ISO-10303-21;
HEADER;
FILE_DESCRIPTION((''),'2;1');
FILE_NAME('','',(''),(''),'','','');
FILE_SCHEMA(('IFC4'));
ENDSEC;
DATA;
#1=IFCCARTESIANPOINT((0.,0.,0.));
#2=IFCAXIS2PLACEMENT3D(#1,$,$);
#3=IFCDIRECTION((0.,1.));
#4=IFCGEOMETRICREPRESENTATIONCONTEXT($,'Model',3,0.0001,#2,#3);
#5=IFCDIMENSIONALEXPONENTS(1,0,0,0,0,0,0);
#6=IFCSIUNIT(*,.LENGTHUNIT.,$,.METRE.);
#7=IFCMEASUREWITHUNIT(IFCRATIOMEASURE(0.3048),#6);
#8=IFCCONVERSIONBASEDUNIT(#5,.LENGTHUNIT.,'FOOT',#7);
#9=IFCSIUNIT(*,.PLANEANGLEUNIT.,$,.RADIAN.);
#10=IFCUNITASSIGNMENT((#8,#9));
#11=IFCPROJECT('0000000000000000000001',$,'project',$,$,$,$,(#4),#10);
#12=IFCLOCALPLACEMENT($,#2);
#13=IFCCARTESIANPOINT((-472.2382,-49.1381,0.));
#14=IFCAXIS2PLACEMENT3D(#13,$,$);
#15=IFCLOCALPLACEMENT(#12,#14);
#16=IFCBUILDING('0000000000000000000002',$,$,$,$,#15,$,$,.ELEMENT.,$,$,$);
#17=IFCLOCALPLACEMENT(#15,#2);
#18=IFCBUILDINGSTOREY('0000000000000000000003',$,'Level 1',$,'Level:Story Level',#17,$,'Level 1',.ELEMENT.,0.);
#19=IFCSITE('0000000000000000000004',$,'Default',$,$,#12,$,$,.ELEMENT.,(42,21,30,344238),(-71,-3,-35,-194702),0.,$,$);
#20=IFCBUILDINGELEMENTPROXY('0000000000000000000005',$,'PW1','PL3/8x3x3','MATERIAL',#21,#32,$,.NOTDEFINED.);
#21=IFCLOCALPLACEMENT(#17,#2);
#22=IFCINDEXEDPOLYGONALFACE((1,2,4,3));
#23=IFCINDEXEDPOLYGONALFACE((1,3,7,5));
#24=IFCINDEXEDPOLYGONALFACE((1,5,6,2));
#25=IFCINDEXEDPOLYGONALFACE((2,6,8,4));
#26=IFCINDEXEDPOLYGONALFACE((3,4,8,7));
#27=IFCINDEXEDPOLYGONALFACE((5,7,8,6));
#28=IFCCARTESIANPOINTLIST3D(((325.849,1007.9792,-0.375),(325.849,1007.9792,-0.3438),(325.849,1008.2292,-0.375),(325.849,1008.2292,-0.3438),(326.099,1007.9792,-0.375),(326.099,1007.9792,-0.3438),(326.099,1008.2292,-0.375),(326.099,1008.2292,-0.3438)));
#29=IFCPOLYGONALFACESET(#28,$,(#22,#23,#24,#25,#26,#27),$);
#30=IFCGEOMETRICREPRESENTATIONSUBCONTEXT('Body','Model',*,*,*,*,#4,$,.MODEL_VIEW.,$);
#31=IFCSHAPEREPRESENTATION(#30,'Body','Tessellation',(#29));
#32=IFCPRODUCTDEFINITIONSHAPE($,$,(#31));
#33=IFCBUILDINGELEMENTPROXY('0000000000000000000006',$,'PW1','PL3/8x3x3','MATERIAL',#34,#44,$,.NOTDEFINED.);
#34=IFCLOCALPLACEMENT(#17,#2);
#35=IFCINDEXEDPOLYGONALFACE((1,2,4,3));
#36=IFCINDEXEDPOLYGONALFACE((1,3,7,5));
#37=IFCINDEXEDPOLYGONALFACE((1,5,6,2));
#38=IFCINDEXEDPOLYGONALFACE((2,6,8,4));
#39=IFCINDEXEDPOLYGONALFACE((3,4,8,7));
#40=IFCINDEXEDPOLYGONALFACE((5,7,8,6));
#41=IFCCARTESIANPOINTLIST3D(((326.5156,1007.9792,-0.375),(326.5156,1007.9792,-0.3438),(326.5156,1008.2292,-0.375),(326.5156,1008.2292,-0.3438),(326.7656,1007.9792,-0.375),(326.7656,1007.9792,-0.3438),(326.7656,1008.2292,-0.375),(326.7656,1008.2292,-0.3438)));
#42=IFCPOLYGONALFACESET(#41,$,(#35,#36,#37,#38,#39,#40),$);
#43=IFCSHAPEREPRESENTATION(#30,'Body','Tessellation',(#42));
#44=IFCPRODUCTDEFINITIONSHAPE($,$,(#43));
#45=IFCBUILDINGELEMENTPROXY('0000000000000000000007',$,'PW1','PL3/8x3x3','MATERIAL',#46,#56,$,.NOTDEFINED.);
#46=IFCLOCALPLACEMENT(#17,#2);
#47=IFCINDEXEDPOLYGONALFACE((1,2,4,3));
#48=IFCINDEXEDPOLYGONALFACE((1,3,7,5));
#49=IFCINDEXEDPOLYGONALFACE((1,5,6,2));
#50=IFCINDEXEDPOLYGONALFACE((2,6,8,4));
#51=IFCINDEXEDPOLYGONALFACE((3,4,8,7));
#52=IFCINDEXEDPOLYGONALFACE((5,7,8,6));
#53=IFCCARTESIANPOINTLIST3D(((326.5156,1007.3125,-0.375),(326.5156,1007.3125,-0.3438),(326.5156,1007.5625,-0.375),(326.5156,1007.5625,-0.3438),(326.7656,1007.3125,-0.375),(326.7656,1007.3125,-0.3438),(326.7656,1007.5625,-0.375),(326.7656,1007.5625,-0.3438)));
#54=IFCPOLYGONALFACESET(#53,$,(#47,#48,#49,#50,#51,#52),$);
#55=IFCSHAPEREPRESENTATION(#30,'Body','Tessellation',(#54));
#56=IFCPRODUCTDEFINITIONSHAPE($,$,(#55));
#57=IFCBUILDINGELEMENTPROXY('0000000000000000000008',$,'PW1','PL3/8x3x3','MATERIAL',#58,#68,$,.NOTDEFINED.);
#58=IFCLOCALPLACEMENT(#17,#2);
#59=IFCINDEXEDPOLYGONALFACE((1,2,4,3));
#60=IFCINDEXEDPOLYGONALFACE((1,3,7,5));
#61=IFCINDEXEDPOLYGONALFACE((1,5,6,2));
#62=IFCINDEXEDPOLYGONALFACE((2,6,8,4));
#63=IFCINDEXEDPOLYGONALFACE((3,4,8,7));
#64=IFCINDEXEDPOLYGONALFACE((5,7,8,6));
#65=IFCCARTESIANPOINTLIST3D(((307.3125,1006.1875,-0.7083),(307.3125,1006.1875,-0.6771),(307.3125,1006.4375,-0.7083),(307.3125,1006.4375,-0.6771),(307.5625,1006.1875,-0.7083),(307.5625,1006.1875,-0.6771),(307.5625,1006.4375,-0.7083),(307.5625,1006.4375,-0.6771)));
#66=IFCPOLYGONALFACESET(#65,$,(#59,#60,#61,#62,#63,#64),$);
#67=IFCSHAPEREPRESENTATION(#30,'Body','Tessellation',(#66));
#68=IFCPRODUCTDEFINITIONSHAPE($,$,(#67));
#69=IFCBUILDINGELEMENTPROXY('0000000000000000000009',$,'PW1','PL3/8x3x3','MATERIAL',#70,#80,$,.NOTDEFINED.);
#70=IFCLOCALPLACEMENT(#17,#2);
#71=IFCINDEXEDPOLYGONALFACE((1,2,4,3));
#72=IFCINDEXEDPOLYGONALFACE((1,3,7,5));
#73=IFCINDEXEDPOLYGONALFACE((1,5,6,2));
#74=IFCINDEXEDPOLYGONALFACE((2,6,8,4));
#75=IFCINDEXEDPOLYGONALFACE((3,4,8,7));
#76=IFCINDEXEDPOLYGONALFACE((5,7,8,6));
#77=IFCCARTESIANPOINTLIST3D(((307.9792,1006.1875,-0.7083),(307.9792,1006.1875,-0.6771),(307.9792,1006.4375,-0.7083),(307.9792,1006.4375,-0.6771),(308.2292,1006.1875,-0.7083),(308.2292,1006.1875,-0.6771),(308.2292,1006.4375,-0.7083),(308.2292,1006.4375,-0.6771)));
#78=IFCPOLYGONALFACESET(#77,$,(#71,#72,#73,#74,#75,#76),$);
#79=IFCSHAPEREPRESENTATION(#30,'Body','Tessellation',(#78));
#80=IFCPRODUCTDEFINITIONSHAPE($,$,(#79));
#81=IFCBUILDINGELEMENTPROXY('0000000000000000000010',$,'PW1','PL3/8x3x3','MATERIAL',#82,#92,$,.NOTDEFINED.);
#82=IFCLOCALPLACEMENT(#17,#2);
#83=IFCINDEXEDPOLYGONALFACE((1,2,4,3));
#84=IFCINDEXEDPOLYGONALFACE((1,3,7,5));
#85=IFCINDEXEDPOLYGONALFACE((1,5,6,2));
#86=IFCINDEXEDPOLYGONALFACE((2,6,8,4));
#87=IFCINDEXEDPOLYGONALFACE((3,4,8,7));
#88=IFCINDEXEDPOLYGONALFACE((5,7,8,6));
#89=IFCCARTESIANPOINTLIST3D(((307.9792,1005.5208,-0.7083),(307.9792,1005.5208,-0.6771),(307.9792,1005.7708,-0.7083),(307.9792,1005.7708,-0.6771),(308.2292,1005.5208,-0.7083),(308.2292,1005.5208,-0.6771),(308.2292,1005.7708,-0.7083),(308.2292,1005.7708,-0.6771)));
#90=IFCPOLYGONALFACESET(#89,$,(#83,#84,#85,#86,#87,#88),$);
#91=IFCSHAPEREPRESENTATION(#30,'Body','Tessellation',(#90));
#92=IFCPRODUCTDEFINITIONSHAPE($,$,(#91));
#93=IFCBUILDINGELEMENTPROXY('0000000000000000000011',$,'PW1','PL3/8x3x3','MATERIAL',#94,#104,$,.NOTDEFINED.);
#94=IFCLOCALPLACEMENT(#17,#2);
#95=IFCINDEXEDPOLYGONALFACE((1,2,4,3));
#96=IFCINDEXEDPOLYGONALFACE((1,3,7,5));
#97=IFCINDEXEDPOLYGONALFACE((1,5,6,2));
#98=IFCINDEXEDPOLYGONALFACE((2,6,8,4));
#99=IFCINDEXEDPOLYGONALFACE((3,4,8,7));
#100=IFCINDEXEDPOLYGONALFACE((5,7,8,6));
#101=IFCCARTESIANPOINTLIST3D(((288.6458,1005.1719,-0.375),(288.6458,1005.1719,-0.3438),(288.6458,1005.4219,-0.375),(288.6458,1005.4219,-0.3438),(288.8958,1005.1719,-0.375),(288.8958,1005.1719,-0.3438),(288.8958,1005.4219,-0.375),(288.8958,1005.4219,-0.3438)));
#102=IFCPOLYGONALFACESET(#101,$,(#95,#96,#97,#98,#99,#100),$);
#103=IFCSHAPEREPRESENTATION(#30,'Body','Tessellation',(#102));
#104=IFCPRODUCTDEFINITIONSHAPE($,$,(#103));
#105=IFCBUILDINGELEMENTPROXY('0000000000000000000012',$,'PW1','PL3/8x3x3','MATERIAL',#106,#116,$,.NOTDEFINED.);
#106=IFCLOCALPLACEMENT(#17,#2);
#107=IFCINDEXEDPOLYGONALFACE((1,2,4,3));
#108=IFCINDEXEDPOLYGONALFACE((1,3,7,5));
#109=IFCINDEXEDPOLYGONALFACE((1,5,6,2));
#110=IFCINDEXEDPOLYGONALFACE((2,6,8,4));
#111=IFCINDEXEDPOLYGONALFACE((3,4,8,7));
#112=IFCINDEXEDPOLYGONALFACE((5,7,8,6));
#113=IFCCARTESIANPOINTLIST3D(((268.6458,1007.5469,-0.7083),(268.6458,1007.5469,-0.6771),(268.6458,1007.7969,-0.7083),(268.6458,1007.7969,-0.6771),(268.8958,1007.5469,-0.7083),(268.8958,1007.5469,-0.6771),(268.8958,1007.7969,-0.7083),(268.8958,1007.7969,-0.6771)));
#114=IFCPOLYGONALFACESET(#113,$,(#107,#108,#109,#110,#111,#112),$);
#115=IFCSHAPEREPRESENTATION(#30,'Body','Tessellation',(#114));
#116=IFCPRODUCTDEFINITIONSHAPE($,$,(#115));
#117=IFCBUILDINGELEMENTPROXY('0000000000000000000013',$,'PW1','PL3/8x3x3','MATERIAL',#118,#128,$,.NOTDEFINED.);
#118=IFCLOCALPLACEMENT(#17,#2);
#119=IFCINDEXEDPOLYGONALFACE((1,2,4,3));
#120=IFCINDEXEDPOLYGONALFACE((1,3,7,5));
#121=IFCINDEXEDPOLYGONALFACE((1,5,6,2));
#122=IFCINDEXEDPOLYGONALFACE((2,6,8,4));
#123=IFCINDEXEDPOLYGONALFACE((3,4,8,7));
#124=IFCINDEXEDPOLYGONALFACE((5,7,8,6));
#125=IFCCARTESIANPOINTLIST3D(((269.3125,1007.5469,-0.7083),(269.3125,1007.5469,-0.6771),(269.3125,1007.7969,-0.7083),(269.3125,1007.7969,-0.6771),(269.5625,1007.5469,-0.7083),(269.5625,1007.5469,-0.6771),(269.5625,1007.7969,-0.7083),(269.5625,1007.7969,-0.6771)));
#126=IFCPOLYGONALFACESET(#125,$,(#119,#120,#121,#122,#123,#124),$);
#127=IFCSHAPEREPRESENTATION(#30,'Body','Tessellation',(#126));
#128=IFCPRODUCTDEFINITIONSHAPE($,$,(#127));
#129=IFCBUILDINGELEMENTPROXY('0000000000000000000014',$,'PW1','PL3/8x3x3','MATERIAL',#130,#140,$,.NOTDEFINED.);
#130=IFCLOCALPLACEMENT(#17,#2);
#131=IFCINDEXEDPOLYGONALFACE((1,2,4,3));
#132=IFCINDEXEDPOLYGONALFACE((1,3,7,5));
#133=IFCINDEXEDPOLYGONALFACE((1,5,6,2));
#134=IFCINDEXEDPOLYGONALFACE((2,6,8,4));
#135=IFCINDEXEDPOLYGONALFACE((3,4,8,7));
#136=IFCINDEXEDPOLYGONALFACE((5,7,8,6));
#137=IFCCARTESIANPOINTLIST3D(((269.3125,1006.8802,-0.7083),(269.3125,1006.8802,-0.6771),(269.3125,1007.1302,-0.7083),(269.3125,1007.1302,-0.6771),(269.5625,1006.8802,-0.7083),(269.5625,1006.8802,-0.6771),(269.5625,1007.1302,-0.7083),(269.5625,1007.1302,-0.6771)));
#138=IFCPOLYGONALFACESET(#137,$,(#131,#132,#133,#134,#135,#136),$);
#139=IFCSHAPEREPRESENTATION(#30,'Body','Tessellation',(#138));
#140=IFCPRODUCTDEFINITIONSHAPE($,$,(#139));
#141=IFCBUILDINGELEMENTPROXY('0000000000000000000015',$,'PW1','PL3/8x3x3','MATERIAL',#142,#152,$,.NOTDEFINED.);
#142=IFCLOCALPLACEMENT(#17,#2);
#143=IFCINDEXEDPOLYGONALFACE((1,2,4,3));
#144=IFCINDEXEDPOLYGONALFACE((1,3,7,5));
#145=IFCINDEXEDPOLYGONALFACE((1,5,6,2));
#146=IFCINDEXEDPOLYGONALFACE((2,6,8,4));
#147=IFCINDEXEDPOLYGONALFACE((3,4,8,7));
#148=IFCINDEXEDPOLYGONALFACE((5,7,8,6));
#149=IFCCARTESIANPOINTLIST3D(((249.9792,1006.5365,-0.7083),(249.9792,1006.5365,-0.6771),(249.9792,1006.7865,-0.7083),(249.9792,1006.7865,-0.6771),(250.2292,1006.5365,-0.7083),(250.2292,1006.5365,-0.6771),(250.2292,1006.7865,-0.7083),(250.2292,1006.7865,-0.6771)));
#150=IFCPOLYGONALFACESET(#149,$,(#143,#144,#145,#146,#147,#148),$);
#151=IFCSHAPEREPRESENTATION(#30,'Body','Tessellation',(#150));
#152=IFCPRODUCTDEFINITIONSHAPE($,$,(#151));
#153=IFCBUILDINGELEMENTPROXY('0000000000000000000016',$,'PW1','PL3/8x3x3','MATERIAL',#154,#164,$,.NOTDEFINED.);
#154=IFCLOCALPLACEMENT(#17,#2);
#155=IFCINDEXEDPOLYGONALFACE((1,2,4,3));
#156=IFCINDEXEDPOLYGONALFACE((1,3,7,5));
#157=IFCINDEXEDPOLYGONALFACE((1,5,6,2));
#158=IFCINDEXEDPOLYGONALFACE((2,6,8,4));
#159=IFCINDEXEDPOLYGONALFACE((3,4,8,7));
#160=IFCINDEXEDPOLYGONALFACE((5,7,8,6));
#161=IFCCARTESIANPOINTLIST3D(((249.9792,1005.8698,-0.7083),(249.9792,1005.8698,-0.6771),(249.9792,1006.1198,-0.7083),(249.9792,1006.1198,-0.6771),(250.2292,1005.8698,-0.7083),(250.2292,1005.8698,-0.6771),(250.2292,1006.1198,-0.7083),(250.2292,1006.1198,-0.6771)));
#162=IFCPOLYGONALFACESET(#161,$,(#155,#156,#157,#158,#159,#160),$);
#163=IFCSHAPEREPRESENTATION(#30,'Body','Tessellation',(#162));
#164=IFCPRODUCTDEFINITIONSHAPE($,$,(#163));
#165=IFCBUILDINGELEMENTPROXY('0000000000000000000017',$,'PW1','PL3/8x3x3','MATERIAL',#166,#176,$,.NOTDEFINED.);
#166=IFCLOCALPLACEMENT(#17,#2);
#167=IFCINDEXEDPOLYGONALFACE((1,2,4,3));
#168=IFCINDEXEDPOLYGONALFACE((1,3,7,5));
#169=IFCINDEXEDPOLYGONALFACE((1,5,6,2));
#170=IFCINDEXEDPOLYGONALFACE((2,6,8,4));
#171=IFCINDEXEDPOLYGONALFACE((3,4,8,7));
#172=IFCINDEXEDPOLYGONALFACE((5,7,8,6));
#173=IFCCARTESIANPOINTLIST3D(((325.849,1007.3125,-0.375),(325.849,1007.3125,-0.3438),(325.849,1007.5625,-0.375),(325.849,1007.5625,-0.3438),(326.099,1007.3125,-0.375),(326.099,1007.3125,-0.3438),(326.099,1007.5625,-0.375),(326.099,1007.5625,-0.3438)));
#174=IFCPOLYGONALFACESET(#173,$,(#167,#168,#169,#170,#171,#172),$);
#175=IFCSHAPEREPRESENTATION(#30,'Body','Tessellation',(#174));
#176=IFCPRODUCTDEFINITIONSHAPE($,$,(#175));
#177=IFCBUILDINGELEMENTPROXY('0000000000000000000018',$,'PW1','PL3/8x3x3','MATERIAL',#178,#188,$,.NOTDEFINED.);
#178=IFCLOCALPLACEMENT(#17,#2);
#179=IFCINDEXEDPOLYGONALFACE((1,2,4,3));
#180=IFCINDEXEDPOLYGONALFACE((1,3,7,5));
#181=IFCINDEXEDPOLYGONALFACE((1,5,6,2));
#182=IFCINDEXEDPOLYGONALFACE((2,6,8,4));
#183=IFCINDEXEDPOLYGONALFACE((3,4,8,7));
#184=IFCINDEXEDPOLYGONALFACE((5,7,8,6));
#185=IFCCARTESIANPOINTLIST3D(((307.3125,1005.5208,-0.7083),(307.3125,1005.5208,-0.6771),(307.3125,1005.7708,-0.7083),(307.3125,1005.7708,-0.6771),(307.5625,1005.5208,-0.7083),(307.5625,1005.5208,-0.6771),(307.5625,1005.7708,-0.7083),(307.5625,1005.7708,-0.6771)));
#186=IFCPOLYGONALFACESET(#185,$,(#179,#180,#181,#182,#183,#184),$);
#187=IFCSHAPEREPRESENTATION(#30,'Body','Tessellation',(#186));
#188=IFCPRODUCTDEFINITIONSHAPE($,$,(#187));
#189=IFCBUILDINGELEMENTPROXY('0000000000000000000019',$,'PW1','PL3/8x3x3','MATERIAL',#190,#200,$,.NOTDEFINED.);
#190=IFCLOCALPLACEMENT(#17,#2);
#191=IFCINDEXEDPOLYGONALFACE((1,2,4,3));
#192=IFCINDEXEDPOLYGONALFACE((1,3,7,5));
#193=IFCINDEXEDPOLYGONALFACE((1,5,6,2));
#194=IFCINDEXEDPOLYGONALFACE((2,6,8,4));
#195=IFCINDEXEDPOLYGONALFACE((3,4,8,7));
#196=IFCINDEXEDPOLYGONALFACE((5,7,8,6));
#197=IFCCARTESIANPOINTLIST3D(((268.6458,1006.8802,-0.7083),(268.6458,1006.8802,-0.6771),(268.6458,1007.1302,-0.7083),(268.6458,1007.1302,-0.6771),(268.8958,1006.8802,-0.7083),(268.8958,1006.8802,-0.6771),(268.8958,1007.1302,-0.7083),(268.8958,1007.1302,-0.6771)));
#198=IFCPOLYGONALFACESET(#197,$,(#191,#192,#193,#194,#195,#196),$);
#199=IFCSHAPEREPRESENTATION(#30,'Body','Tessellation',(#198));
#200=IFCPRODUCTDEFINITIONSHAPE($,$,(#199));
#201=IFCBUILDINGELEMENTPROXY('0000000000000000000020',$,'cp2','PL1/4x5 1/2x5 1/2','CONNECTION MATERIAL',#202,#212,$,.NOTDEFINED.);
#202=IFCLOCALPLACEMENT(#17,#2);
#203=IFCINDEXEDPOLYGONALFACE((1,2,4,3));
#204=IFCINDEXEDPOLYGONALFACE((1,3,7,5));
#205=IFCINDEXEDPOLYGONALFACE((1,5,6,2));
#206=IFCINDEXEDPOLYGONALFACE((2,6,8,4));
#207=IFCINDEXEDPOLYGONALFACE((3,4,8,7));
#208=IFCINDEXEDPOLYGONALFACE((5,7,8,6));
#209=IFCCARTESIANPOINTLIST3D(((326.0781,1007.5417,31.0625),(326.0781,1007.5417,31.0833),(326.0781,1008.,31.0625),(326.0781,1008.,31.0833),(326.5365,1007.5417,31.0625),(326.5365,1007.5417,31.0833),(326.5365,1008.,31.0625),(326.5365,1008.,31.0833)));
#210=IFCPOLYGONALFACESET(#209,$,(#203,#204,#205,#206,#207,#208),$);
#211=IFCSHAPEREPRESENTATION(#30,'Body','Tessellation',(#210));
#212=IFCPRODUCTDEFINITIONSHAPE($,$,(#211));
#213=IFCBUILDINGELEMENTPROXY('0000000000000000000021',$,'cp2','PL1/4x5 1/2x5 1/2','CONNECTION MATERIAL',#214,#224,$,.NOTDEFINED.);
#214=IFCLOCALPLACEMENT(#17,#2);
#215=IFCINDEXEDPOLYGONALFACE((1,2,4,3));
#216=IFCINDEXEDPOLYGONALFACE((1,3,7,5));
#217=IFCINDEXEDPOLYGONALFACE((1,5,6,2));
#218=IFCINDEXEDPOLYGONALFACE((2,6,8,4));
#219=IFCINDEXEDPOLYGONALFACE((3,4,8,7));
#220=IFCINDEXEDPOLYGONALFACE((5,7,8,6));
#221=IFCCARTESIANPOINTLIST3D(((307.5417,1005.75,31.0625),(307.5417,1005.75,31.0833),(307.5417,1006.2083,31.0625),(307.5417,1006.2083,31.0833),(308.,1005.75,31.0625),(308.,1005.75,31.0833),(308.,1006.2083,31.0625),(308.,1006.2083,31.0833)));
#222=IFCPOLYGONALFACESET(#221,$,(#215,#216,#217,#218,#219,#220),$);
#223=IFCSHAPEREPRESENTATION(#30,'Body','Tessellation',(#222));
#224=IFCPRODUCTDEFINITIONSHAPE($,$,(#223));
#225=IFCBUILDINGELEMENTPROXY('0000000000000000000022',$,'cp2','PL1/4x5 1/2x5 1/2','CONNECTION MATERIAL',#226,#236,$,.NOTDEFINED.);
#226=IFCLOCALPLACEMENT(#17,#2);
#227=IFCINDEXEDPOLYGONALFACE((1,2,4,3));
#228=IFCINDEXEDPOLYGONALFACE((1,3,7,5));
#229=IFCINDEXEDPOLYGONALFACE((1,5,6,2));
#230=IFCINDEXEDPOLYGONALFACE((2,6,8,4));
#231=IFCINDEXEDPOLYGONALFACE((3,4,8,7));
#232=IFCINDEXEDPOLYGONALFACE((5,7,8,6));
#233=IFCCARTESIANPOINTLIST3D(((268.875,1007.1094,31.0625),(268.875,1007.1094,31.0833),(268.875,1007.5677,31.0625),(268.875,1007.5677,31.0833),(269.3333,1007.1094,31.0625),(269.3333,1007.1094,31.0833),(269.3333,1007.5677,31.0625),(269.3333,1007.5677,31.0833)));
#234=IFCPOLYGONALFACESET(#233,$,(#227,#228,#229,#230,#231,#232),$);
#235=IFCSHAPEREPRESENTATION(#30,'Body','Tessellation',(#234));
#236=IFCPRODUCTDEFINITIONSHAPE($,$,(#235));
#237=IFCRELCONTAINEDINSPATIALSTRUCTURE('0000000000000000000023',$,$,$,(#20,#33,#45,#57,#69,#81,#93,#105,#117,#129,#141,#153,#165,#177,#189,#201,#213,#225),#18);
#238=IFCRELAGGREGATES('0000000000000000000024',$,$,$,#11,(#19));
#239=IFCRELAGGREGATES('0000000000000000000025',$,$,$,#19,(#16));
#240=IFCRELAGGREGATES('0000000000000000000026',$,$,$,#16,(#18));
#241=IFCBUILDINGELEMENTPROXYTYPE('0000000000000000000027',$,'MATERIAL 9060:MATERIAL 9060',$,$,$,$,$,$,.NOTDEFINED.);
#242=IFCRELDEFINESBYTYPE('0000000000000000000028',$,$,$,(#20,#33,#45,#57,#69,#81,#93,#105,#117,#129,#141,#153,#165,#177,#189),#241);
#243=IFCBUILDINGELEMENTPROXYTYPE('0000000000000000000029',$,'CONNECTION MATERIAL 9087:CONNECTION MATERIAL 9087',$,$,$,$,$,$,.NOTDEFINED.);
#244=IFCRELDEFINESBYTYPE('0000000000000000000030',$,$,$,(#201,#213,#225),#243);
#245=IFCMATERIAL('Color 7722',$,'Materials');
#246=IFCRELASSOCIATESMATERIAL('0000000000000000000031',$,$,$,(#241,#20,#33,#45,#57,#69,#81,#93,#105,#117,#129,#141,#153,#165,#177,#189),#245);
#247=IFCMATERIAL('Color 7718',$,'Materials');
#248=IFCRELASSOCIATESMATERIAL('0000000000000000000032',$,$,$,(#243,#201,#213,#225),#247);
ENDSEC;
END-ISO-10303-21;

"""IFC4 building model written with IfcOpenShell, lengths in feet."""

from ifc_helpers import new_model, entity, si_unit, converted_unit, direction, frame, origin, origin_2d_with_axis, place, context, subcontext, project, spatial, rectangle, extrude, source, transform, mapped, material, type_object, type_shapes, element, save


model = new_model("IFC4")

# Units and contexts
model_context = context("Model", 3, precision=0.0001, world=origin(), true_north=direction((0.0, 1.0)))
body_context = subcontext(model_context, "Body", "Model", "MODEL_VIEW")
ifc_project = project(units=[converted_unit("LENGTHUNIT", "FOOT", entity("IfcRatioMeasure", 0.3048), si_unit("LENGTHUNIT", "METRE"), dimensions=[1, 0, 0, 0, 0, 0, 0]), si_unit("PLANEANGLEUNIT", "RADIAN")], contexts=[model_context])

# Site, building, storey
site_placement = place(None, origin())
site = spatial("IfcSite", under=ifc_project, at=site_placement, Name="Default", CompositionType="ELEMENT", RefLatitude=(42, 21, 30, 344238), RefLongitude=(-71, -3, -35, -194702), RefElevation=0.0)
building_placement = place(site_placement, frame((-472.2382, -49.1381, 0.0)))
building = spatial("IfcBuilding", under=site, at=building_placement, CompositionType="ELEMENT")
storey_placement = place(building_placement, origin())
storey = spatial("IfcBuildingStorey", under=building, at=storey_placement, Name="Level 1", ObjectType="Level:Story Level", LongName="Level 1", CompositionType="ELEMENT", Elevation=0.0)

# Building element proxies
ifc_material_1 = material(Name="Color 7722", Category="Materials")
building_element_proxy_type_1 = type_object("IfcBuildingElementProxyType", Name="MATERIAL 9060:MATERIAL 9060", PredefinedType="NOTDEFINED", material=ifc_material_1)
shared_shape_1 = source(origin(), body_context, "Body", "SweptSolid", [
    extrude(rectangle(XDim=0.25, YDim=0.25, at=origin_2d_with_axis()), frame((0.125, -0.125, 0.0)), (0.0, 0.0, 1.0), 0.0312),
])
type_shapes(building_element_proxy_type_1, [shared_shape_1])
for number, where, z_axis, x_axis, name in (
    (1, (325.849, 1008.2292, -0.3438), (0.0, 0.0, -1.0), (0.0, -1.0, 0.0), "PW1"),
    (2, (326.5156, 1008.2292, -0.3438), (0.0, 0.0, -1.0), (0.0, -1.0, 0.0), "PW1"),
    (3, (326.5156, 1007.5625, -0.3438), (0.0, 0.0, -1.0), (0.0, -1.0, 0.0), "PW1"),
    (4, (307.3125, 1006.4375, -0.6771), (0.0, 0.0, -1.0), (0.0, -1.0, 0.0), "PW1"),
    (5, (307.9792, 1006.4375, -0.6771), (0.0, 0.0, -1.0), (0.0, -1.0, 0.0), "PW1"),
    (6, (307.9792, 1005.7708, -0.6771), (0.0, 0.0, -1.0), (0.0, -1.0, 0.0), "PW1"),
    (7, (288.6458, 1005.4219, -0.3438), (0.0, 0.0, -1.0), (0.0, -1.0, 0.0), "PW1"),
    (8, (268.6458, 1007.7969, -0.6771), (0.0, 0.0, -1.0), (0.0, -1.0, 0.0), "PW1"),
    (9, (269.3125, 1007.7969, -0.6771), (0.0, 0.0, -1.0), (0.0, -1.0, 0.0), "PW1"),
    (10, (269.3125, 1007.1302, -0.6771), (0.0, 0.0, -1.0), (0.0, -1.0, 0.0), "PW1"),
    (11, (249.9792, 1006.7865, -0.6771), (0.0, 0.0, -1.0), (0.0, -1.0, 0.0), "PW1"),
    (12, (249.9792, 1006.1198, -0.6771), (0.0, 0.0, -1.0), (0.0, -1.0, 0.0), "PW1"),
    (13, (325.849, 1007.5625, -0.3438), (0.0, 0.0, -1.0), (0.0, -1.0, 0.0), "PW1"),
    (14, (307.3125, 1005.7708, -0.6771), (0.0, 0.0, -1.0), (0.0, -1.0, 0.0), "PW1"),
    (15, (268.6458, 1007.1302, -0.6771), (0.0, 0.0, -1.0), (0.0, -1.0, 0.0), "PW1"),
):
    element("IfcBuildingElementProxy", number, at=place(building_placement, frame(where, z_axis=z_axis, x_axis=x_axis)), inside=storey, type_object=building_element_proxy_type_1, material=ifc_material_1, Name=name, Description="PL3/8x3x3", ObjectType="MATERIAL", PredefinedType="NOTDEFINED", context=body_context, shape_type="MappedRepresentation", body=[
        mapped(shared_shape_1, transform((0.0, 0.0, 0.0), scale=1.0)),
    ])
ifc_material_2 = material(Name="Color 7718", Category="Materials")
building_element_proxy_type_2 = type_object("IfcBuildingElementProxyType", Name="CONNECTION MATERIAL 9087:CONNECTION MATERIAL 9087", PredefinedType="NOTDEFINED", material=ifc_material_2)
shared_shape_2 = source(origin(), body_context, "Body", "SweptSolid", [
    extrude(rectangle(XDim=0.4583, YDim=0.4583, at=origin_2d_with_axis()), frame((0.0, 0.0, -0.0208)), (0.0, 0.0, 1.0), 0.0208),
])
type_shapes(building_element_proxy_type_2, [shared_shape_2])
for number, where, z_axis, x_axis, name in (
    (16, (326.3073, 1007.7708, 31.0625), (0.0, 0.0, -1.0), (1.0, 0.0, 0.0), "cp2"),
    (17, (307.7708, 1005.9792, 31.0625), (0.0, 0.0, -1.0), (1.0, 0.0, 0.0), "cp2"),
    (18, (269.1042, 1007.3385, 31.0625), (0.0, 0.0, -1.0), (1.0, 0.0, 0.0), "cp2"),
):
    element("IfcBuildingElementProxy", number, at=place(building_placement, frame(where, z_axis=z_axis, x_axis=x_axis)), inside=storey, type_object=building_element_proxy_type_2, material=ifc_material_2, Name=name, Description="PL1/4x5 1/2x5 1/2", ObjectType="CONNECTION MATERIAL", PredefinedType="NOTDEFINED", context=body_context, shape_type="MappedRepresentation", body=[
        mapped(shared_shape_2, transform((0.0, 0.0, 0.0), scale=1.0)),
    ])

save(model, "model.ifc")
